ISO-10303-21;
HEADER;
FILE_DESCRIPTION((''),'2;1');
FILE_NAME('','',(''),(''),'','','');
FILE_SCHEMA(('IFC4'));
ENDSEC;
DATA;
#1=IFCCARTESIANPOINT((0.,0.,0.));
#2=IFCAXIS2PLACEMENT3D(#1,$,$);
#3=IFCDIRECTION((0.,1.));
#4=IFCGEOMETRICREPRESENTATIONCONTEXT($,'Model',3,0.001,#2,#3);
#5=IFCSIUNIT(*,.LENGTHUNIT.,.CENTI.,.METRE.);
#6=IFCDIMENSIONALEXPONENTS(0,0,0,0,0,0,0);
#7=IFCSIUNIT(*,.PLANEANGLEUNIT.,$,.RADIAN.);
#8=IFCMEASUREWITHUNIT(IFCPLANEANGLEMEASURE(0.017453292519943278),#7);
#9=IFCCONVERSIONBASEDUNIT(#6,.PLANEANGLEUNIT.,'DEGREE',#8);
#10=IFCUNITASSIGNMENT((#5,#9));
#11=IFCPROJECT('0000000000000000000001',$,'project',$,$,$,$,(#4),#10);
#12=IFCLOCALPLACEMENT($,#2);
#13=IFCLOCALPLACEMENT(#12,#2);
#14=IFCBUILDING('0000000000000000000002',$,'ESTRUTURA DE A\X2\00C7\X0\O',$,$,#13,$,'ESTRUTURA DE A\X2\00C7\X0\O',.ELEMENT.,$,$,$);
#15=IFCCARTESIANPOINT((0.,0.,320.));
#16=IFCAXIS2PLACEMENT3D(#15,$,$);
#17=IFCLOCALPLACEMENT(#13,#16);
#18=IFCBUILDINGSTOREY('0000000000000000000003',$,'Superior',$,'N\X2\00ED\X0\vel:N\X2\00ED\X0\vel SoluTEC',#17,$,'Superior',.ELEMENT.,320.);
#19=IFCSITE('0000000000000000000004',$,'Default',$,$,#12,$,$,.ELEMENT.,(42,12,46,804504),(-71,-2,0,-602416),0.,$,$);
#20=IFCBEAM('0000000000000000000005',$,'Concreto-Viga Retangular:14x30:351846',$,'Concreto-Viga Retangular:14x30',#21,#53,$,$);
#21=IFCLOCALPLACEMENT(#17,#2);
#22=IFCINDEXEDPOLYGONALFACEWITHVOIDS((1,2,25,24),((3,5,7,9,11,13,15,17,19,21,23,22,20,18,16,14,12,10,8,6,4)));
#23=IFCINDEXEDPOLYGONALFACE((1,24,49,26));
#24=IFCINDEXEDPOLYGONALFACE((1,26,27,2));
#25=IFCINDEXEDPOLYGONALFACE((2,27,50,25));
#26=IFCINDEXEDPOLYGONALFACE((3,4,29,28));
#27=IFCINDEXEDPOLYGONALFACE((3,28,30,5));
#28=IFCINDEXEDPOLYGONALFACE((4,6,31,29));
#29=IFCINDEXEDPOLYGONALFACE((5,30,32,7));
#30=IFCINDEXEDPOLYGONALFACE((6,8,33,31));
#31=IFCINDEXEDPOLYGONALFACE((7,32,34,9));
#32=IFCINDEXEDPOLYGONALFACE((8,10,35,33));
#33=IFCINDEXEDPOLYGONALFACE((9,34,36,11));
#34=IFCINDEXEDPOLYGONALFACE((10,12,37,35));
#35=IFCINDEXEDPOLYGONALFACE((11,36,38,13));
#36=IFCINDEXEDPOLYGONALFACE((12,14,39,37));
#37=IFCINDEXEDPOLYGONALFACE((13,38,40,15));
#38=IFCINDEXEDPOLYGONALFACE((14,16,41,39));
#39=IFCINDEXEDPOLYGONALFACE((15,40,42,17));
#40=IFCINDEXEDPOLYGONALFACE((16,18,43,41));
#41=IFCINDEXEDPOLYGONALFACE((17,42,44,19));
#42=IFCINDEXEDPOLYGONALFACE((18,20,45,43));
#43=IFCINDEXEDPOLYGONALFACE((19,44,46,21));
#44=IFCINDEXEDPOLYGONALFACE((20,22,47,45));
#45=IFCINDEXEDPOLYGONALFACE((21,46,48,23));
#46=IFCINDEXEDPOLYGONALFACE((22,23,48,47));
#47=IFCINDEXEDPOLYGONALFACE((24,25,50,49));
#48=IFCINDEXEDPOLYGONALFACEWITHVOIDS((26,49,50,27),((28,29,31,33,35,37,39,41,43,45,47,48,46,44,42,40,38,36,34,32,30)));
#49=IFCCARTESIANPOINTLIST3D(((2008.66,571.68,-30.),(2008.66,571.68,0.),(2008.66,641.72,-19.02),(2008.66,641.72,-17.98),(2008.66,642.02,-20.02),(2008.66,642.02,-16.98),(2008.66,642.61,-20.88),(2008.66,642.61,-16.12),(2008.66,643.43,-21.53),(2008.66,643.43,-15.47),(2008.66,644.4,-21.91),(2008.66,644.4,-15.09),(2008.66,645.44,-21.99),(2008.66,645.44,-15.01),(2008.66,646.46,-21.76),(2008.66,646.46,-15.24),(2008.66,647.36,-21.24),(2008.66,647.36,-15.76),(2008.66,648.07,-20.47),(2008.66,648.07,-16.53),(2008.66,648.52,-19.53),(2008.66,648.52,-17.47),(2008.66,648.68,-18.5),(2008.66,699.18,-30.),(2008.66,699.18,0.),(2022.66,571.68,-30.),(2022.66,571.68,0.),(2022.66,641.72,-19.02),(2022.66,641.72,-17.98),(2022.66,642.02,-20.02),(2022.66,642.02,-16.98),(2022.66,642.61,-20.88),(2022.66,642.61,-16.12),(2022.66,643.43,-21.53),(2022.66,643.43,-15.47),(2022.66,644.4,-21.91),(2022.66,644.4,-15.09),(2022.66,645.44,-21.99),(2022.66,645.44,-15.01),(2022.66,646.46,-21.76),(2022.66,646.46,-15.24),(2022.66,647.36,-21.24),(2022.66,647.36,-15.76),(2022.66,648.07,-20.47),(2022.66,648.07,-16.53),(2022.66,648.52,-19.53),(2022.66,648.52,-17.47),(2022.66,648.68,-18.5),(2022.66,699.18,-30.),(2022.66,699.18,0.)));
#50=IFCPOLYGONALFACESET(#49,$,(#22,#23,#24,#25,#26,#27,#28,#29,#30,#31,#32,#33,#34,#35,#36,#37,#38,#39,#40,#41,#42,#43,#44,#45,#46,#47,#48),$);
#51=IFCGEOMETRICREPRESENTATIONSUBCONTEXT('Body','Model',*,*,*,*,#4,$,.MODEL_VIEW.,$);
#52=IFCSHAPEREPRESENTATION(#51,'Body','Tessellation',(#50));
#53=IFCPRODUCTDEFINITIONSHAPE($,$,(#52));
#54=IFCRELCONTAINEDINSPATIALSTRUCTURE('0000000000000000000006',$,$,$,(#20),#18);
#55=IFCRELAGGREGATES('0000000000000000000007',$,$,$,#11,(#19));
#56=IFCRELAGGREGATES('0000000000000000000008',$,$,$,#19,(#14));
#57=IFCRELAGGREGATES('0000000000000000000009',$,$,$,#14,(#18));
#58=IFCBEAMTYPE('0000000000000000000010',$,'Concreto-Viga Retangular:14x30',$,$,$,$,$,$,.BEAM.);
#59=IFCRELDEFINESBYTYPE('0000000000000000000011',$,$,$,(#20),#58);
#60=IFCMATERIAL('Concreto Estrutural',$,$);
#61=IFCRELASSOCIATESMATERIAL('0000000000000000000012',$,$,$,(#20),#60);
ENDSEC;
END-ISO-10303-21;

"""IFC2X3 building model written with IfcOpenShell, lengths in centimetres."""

from ifc_helpers import new_model, entity, si_unit, converted_unit, direction, frame, frame_2d, origin, origin_2d_with_axis, place, context, subcontext, project, spatial, rectangle, circle, extrude, boolean, material, type_object, element, save


model = new_model("IFC2X3")

# Units and contexts
model_context = context("Model", 3, precision=0.001, world=origin(), true_north=direction((0.0, 1.0)))
body_context = subcontext(model_context, "Body", "Model", "MODEL_VIEW")
ifc_project = project(units=[si_unit("LENGTHUNIT", "METRE", prefix="CENTI"), converted_unit("PLANEANGLEUNIT", "DEGREE", entity("IfcPlaneAngleMeasure", 0.017453292519943278), si_unit("PLANEANGLEUNIT", "RADIAN"), dimensions=[0, 0, 0, 0, 0, 0, 0])], contexts=[model_context])

# Site, building, storey
site_placement = place(None, origin())
site = spatial("IfcSite", under=ifc_project, at=site_placement, Name="Default", CompositionType="ELEMENT", RefLatitude=(42, 12, 46, 804504), RefLongitude=(-71, -2, 0, -602416), RefElevation=0.0)
building_placement = place(site_placement, origin())
building = spatial("IfcBuilding", under=site, at=building_placement, Name="ESTRUTURA DE AÇO", LongName="ESTRUTURA DE AÇO", CompositionType="ELEMENT")
storey_placement = place(building_placement, frame((0.0, 0.0, 320.0)))
storey = spatial("IfcBuildingStorey", under=building, at=storey_placement, Name="Superior", ObjectType="Nível:Nível SoluTEC", LongName="Superior", CompositionType="ELEMENT", Elevation=320.0)

# Shared definitions
ifc_material = material(Name="Concreto Estrutural")

# Beam
beam_type_1 = type_object("IfcBeamType", Name="Concreto-Viga Retangular:14x30", PredefinedType="BEAM")
beam_1_placement = place(storey_placement, frame((2015.66, 571.68, 0.0), z_axis=(0.0, 0.0, 1.0), x_axis=(0.0, 1.0, 0.0)))
element("IfcBeam", 1, at=beam_1_placement, inside=storey, type_object=beam_type_1, material=ifc_material, Name="Concreto-Viga Retangular:14x30:351846", ObjectType="Concreto-Viga Retangular:14x30", context=body_context, shape_type="SweptSolid", body=[
    boolean("DIFFERENCE", extrude(rectangle(XDim=30.0, YDim=14.0, at=frame_2d((0.0, 0.0), x_axis=(0.0, 1.0))), frame((0.0, 0.0, -15.0), z_axis=(1.0, 0.0, 0.0), x_axis=(0.0, 1.0, 0.0)), (0.0, 0.0, 1.0), 127.5), extrude(circle(Radius=3.5, at=origin_2d_with_axis()), frame((73.5, -7.0, -18.5), z_axis=(0.0, 1.0, 0.0), x_axis=(1.0, 0.0, 0.0)), (0.0, 0.0, 1.0), 14.0)),
])

save(model, "model.ifc")
